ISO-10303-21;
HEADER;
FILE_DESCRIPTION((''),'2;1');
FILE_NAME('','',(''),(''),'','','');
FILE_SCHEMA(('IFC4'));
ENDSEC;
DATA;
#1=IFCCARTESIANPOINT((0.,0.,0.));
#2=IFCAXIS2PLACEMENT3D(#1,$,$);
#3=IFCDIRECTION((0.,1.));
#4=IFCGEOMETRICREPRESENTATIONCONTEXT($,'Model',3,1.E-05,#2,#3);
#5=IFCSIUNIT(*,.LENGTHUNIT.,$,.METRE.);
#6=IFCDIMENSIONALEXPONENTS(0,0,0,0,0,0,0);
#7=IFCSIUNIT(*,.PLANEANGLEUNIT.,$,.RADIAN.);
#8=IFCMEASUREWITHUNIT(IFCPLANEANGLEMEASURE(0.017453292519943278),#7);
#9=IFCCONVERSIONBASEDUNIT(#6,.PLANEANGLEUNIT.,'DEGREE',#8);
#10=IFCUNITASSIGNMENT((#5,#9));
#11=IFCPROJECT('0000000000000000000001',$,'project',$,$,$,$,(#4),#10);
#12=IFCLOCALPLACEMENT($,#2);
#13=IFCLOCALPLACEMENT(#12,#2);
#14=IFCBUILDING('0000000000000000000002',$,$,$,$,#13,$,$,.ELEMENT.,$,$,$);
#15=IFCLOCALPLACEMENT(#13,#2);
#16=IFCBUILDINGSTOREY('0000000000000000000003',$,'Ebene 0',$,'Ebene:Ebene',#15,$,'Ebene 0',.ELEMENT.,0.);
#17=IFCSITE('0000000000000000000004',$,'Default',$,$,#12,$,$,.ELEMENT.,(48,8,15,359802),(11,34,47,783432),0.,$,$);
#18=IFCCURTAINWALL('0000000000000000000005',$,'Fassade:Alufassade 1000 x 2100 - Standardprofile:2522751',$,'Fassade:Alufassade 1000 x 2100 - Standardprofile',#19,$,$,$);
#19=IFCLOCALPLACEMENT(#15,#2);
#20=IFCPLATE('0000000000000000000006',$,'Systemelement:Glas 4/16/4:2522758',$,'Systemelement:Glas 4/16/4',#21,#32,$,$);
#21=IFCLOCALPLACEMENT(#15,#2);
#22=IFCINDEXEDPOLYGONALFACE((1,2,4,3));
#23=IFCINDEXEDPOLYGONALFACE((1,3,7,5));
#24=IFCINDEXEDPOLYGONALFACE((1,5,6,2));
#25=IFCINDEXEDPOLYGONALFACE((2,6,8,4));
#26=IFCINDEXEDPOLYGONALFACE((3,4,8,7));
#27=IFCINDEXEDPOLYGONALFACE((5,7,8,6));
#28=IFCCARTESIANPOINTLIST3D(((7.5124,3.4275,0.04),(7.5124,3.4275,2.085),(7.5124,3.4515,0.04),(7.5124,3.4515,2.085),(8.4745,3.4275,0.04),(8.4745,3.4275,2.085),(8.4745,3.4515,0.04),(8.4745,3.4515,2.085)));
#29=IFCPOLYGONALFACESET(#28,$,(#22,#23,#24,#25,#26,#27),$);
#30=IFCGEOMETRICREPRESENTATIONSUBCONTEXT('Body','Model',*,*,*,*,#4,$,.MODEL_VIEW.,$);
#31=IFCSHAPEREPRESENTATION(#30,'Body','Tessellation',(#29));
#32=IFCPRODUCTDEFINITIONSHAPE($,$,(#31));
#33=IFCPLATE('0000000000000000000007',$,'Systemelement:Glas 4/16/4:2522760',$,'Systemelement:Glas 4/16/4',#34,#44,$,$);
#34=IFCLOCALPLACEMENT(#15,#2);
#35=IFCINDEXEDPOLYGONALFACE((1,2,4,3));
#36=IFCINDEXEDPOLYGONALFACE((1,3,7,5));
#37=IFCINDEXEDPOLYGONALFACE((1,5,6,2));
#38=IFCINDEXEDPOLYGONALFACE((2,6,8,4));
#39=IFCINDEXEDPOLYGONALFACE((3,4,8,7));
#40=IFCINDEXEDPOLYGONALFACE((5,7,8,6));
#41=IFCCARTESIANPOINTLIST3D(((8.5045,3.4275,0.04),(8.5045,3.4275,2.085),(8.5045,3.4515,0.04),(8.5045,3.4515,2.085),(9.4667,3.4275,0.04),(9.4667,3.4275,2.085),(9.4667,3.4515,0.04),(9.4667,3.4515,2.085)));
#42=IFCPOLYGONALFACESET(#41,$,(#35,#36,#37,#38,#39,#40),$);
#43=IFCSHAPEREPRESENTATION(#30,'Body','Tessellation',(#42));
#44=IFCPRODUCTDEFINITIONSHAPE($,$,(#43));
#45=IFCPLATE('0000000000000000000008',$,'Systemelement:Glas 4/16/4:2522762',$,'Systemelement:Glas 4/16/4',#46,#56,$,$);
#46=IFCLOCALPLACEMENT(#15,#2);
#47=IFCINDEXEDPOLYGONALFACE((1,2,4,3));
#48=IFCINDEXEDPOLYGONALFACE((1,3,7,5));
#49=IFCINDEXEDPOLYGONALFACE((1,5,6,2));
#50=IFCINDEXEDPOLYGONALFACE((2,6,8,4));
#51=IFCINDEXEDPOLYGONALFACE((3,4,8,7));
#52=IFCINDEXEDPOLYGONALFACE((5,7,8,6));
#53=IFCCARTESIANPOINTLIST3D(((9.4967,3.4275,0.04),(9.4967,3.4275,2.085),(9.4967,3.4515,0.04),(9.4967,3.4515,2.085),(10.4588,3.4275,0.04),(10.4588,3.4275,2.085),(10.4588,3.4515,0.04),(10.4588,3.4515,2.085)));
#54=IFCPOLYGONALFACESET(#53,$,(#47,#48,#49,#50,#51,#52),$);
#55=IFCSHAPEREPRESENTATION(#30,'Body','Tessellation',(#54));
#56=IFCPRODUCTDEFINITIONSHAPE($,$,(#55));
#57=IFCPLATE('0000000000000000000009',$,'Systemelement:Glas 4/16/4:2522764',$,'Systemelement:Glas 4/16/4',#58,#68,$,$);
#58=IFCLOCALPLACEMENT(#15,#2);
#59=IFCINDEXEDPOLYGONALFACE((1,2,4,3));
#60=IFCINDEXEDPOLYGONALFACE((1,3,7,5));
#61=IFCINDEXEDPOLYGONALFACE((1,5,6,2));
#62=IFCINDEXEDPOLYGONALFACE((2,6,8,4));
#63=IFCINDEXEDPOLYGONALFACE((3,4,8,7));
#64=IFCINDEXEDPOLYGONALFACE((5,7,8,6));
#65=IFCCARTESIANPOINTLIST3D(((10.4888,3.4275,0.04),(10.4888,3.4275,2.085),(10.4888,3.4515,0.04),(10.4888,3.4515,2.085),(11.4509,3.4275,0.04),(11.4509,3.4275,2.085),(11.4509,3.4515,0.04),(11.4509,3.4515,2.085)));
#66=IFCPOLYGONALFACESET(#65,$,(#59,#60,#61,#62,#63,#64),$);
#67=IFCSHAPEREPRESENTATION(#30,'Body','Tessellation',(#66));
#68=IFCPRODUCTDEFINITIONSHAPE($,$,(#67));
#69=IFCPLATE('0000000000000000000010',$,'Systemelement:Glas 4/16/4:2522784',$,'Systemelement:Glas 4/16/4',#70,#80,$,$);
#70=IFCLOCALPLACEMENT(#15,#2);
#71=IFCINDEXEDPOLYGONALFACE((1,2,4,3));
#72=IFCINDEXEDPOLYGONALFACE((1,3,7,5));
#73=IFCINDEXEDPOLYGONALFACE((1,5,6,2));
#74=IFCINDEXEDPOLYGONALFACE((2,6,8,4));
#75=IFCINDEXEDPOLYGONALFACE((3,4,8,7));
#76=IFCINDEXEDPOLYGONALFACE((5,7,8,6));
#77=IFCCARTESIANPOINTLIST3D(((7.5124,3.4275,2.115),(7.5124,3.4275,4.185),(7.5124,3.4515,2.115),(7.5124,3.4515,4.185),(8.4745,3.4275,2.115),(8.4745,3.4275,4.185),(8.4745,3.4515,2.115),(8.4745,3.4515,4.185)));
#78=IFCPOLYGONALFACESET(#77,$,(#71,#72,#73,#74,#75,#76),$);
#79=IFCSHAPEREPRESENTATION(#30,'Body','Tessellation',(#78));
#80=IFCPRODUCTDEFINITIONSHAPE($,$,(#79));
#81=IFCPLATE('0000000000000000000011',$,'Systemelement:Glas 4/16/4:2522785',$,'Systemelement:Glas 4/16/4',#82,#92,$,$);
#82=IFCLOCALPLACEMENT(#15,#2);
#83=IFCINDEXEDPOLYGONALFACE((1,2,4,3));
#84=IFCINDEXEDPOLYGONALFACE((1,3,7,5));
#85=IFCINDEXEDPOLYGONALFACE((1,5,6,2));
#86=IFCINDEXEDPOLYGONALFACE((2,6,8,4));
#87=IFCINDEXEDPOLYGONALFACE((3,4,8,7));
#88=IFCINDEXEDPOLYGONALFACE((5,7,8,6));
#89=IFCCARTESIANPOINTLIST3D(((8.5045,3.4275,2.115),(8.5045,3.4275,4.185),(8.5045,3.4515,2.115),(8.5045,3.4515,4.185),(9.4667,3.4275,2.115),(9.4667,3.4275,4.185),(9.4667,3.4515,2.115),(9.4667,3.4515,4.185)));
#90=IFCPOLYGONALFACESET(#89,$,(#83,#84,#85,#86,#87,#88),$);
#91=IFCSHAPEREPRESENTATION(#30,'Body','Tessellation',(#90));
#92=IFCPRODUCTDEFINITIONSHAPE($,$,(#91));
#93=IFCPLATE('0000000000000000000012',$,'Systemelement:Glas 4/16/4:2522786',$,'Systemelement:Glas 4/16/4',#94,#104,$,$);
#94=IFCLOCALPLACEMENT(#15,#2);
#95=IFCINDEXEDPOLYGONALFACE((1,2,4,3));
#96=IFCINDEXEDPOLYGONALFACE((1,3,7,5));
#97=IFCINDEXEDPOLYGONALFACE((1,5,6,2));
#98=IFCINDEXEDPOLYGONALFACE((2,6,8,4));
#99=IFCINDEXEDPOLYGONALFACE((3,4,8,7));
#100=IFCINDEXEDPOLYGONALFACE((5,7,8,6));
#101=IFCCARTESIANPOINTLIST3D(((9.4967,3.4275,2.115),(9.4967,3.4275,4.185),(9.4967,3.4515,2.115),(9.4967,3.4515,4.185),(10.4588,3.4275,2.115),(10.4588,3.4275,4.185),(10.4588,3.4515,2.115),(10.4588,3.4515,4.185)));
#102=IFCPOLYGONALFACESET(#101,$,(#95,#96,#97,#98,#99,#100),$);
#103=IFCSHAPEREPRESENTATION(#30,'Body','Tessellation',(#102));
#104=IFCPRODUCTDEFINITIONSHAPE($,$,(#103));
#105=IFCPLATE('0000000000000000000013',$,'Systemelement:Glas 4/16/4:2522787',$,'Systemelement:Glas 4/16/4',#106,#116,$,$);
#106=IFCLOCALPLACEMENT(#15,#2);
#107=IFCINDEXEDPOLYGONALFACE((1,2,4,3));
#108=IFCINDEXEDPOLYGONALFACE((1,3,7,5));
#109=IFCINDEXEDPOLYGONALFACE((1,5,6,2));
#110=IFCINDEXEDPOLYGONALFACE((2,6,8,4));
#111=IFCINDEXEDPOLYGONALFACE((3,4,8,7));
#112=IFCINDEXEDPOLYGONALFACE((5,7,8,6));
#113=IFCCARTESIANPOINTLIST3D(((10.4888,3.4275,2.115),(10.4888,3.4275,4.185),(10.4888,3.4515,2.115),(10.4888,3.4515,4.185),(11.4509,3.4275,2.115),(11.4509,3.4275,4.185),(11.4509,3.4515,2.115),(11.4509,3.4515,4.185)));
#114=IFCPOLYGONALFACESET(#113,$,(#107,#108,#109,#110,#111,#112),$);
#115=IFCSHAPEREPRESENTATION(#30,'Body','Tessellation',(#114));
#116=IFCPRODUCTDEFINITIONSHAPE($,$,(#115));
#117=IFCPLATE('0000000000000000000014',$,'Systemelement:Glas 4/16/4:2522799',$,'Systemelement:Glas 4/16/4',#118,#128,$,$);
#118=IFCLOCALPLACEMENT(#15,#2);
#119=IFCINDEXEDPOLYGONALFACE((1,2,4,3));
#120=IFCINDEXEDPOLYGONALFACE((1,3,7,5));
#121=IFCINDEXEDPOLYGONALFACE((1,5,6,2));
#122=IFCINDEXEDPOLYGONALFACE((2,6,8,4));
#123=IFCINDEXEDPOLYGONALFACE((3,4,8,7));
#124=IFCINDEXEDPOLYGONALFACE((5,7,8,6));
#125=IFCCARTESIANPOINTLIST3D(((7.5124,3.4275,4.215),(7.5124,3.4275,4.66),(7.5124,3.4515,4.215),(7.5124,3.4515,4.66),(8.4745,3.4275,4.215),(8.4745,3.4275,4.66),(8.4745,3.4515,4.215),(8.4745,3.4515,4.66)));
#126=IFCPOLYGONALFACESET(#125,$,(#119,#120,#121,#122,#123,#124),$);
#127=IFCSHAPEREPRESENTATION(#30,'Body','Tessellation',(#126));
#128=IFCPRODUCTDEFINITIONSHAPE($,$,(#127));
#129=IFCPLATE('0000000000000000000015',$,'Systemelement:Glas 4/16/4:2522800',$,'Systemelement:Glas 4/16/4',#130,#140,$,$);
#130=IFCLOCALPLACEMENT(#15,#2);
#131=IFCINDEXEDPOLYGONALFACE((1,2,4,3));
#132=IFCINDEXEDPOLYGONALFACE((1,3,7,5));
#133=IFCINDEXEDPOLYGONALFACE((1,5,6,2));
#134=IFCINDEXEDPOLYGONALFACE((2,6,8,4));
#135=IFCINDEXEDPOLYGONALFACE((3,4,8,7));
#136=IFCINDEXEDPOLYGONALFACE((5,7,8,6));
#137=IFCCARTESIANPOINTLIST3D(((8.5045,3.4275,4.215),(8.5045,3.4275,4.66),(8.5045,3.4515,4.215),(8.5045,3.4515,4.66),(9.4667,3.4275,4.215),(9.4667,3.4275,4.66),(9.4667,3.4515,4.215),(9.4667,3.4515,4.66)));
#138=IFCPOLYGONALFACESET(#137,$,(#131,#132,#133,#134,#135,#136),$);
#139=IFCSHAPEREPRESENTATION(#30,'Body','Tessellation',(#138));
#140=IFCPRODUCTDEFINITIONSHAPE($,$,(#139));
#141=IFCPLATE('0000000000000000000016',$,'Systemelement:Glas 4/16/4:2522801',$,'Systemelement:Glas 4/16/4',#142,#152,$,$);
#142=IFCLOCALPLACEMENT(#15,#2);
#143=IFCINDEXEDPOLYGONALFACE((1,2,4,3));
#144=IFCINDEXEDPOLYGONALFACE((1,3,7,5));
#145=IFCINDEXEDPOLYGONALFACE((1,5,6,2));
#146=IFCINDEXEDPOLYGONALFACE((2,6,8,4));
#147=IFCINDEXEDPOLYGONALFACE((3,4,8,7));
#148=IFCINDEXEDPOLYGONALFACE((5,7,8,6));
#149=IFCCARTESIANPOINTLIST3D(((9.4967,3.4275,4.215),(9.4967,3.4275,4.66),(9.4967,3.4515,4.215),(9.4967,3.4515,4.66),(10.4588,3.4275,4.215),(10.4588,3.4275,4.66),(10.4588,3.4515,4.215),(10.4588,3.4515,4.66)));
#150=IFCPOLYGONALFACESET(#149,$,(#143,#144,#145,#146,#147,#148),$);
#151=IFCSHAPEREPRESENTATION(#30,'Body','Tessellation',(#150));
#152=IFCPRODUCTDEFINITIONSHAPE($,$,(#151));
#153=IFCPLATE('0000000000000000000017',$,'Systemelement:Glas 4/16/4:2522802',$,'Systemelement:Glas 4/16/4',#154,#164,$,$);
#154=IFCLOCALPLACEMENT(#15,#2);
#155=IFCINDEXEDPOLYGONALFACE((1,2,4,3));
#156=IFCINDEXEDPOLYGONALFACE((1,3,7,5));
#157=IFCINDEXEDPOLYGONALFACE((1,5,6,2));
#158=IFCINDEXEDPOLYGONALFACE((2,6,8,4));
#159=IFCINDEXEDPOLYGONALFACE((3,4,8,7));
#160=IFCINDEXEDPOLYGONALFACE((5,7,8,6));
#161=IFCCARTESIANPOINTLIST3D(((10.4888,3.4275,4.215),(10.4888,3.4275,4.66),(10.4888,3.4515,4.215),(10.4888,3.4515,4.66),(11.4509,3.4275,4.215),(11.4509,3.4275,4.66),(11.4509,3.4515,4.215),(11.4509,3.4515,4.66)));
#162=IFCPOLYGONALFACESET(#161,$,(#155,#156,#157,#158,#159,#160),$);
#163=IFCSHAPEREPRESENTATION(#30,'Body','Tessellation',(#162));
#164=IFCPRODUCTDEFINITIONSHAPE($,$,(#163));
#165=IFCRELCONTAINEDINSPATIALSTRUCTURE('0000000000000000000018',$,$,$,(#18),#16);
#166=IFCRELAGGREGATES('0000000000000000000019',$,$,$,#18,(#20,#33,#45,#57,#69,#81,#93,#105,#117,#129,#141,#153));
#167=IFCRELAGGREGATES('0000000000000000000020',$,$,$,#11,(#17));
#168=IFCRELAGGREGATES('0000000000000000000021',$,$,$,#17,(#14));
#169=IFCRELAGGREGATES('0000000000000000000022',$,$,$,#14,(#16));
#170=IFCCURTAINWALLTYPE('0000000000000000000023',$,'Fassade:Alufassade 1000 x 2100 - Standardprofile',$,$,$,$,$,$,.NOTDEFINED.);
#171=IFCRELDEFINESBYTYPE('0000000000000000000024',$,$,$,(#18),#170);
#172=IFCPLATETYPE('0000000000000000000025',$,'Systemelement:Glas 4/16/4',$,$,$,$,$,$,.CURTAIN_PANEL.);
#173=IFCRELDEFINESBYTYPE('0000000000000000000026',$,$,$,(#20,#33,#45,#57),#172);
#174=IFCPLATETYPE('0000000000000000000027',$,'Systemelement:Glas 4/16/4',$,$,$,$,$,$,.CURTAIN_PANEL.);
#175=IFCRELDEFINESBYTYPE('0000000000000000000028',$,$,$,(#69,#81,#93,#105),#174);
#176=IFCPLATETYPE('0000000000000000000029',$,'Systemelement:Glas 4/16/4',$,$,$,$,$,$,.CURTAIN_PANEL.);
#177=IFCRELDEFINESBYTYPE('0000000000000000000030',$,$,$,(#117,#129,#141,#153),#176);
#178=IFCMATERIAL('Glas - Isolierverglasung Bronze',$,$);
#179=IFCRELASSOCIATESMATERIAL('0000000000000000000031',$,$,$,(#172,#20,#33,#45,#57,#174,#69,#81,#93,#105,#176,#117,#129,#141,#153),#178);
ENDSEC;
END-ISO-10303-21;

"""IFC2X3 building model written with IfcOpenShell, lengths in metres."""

from ifc_helpers import new_model, entity, si_unit, converted_unit, direction, frame, origin, origin_2d_with_axis, place, context, subcontext, project, spatial, rectangle, extrude, source, transform, mapped, material, type_object, type_shapes, element, aggregate, save


model = new_model("IFC2X3")

# Units and contexts
model_context = context("Model", 3, precision=1e-05, world=origin(), true_north=direction((0.0, 1.0)))
body_context = subcontext(model_context, "Body", "Model", "MODEL_VIEW")
ifc_project = project(units=[si_unit("LENGTHUNIT", "METRE"), converted_unit("PLANEANGLEUNIT", "DEGREE", entity("IfcPlaneAngleMeasure", 0.017453292519943278), si_unit("PLANEANGLEUNIT", "RADIAN"), dimensions=[0, 0, 0, 0, 0, 0, 0])], contexts=[model_context])

# Site, building, storey
site_placement = place(None, origin())
site = spatial("IfcSite", under=ifc_project, at=site_placement, Name="Default", CompositionType="ELEMENT", RefLatitude=(48, 8, 15, 359802), RefLongitude=(11, 34, 47, 783432), RefElevation=0.0)
building_placement = place(site_placement, origin())
building = spatial("IfcBuilding", under=site, at=building_placement, CompositionType="ELEMENT")
storey_placement = place(building_placement, origin())
storey = spatial("IfcBuildingStorey", under=building, at=storey_placement, Name="Ebene 0", ObjectType="Ebene:Ebene", LongName="Ebene 0", CompositionType="ELEMENT", Elevation=0.0)

# Curtain wall, plates
curtain_wall_type = type_object("IfcCurtainWallType", Name="Fassade:Alufassade 1000 x 2100 - Standardprofile", PredefinedType="NOTDEFINED")
curtain_wall_placement = place(storey_placement, origin())
curtain_wall = element("IfcCurtainWall", 1, at=curtain_wall_placement, inside=storey, type_object=curtain_wall_type, Name="Fassade:Alufassade 1000 x 2100 - Standardprofile:2522751", ObjectType="Fassade:Alufassade 1000 x 2100 - Standardprofile")
ifc_material_1 = material(Name="Glas - Isolierverglasung Bronze")
plate_type_1 = type_object("IfcPlateType", Name="Systemelement:Glas 4/16/4", PredefinedType="CURTAIN_PANEL", material=ifc_material_1)
shared_shape_1 = source(origin(), body_context, "Body", "SweptSolid", [
    extrude(rectangle(XDim=0.024, YDim=0.9621, at=origin_2d_with_axis()), frame((0.0, 0.0, 0.0), z_axis=(0.0, 0.0, 1.0), x_axis=(0.0, 1.0, 0.0)), (0.0, 0.0, 1.0), 2.045),
])
type_shapes(plate_type_1, [shared_shape_1])
plate_1_placement = place(curtain_wall_placement, frame((7.9934, 3.4395, 0.04)))
plate_1 = element("IfcPlate", 2, at=plate_1_placement, type_object=plate_type_1, material=ifc_material_1, Name="Systemelement:Glas 4/16/4:2522758", ObjectType="Systemelement:Glas 4/16/4", context=body_context, shape_type="MappedRepresentation", body=[
    mapped(shared_shape_1, transform((0.0, 0.0, 0.0), scale=1.0)),
])
plate_2_placement = place(curtain_wall_placement, frame((8.9856, 3.4395, 0.04)))
plate_2 = element("IfcPlate", 3, at=plate_2_placement, type_object=plate_type_1, material=ifc_material_1, Name="Systemelement:Glas 4/16/4:2522760", ObjectType="Systemelement:Glas 4/16/4", context=body_context, shape_type="MappedRepresentation", body=[
    mapped(shared_shape_1, transform((0.0, 0.0, 0.0), scale=1.0)),
])
plate_3_placement = place(curtain_wall_placement, frame((9.9777, 3.4395, 0.04)))
plate_3 = element("IfcPlate", 4, at=plate_3_placement, type_object=plate_type_1, material=ifc_material_1, Name="Systemelement:Glas 4/16/4:2522762", ObjectType="Systemelement:Glas 4/16/4", context=body_context, shape_type="MappedRepresentation", body=[
    mapped(shared_shape_1, transform((0.0, 0.0, 0.0), scale=1.0)),
])
plate_4_placement = place(curtain_wall_placement, frame((10.9699, 3.4395, 0.04)))
plate_4 = element("IfcPlate", 5, at=plate_4_placement, type_object=plate_type_1, material=ifc_material_1, Name="Systemelement:Glas 4/16/4:2522764", ObjectType="Systemelement:Glas 4/16/4", context=body_context, shape_type="MappedRepresentation", body=[
    mapped(shared_shape_1, transform((0.0, 0.0, 0.0), scale=1.0)),
])
plate_type_2 = type_object("IfcPlateType", Name="Systemelement:Glas 4/16/4", PredefinedType="CURTAIN_PANEL", material=ifc_material_1)
shared_shape_2 = source(origin(), body_context, "Body", "SweptSolid", [
    extrude(rectangle(XDim=0.024, YDim=0.9621, at=origin_2d_with_axis()), frame((0.0, 0.0, 0.0), z_axis=(0.0, 0.0, 1.0), x_axis=(0.0, 1.0, 0.0)), (0.0, 0.0, 1.0), 2.07),
])
type_shapes(plate_type_2, [shared_shape_2])
plate_5_placement = place(curtain_wall_placement, frame((7.9934, 3.4395, 2.115)))
plate_5 = element("IfcPlate", 6, at=plate_5_placement, type_object=plate_type_2, material=ifc_material_1, Name="Systemelement:Glas 4/16/4:2522784", ObjectType="Systemelement:Glas 4/16/4", context=body_context, shape_type="MappedRepresentation", body=[
    mapped(shared_shape_2, transform((0.0, 0.0, 0.0), scale=1.0)),
])
plate_6_placement = place(curtain_wall_placement, frame((8.9856, 3.4395, 2.115)))
plate_6 = element("IfcPlate", 7, at=plate_6_placement, type_object=plate_type_2, material=ifc_material_1, Name="Systemelement:Glas 4/16/4:2522785", ObjectType="Systemelement:Glas 4/16/4", context=body_context, shape_type="MappedRepresentation", body=[
    mapped(shared_shape_2, transform((0.0, 0.0, 0.0), scale=1.0)),
])
plate_7_placement = place(curtain_wall_placement, frame((9.9777, 3.4395, 2.115)))
plate_7 = element("IfcPlate", 8, at=plate_7_placement, type_object=plate_type_2, material=ifc_material_1, Name="Systemelement:Glas 4/16/4:2522786", ObjectType="Systemelement:Glas 4/16/4", context=body_context, shape_type="MappedRepresentation", body=[
    mapped(shared_shape_2, transform((0.0, 0.0, 0.0), scale=1.0)),
])
plate_8_placement = place(curtain_wall_placement, frame((10.9699, 3.4395, 2.115)))
plate_8 = element("IfcPlate", 9, at=plate_8_placement, type_object=plate_type_2, material=ifc_material_1, Name="Systemelement:Glas 4/16/4:2522787", ObjectType="Systemelement:Glas 4/16/4", context=body_context, shape_type="MappedRepresentation", body=[
    mapped(shared_shape_2, transform((0.0, 0.0, 0.0), scale=1.0)),
])
plate_type_3 = type_object("IfcPlateType", Name="Systemelement:Glas 4/16/4", PredefinedType="CURTAIN_PANEL", material=ifc_material_1)
shared_shape_3 = source(origin(), body_context, "Body", "SweptSolid", [
    extrude(rectangle(XDim=0.024, YDim=0.9621, at=origin_2d_with_axis()), frame((0.0, 0.0, 0.0), z_axis=(0.0, 0.0, 1.0), x_axis=(0.0, 1.0, 0.0)), (0.0, 0.0, 1.0), 0.445),
])
type_shapes(plate_type_3, [shared_shape_3])
plate_9_placement = place(curtain_wall_placement, frame((7.9934, 3.4395, 4.215)))
plate_9 = element("IfcPlate", 10, at=plate_9_placement, type_object=plate_type_3, material=ifc_material_1, Name="Systemelement:Glas 4/16/4:2522799", ObjectType="Systemelement:Glas 4/16/4", context=body_context, shape_type="MappedRepresentation", body=[
    mapped(shared_shape_3, transform((0.0, 0.0, 0.0), scale=1.0)),
])
plate_10_placement = place(curtain_wall_placement, frame((8.9856, 3.4395, 4.215)))
plate_10 = element("IfcPlate", 11, at=plate_10_placement, type_object=plate_type_3, material=ifc_material_1, Name="Systemelement:Glas 4/16/4:2522800", ObjectType="Systemelement:Glas 4/16/4", context=body_context, shape_type="MappedRepresentation", body=[
    mapped(shared_shape_3, transform((0.0, 0.0, 0.0), scale=1.0)),
])
plate_11_placement = place(curtain_wall_placement, frame((9.9777, 3.4395, 4.215)))
plate_11 = element("IfcPlate", 12, at=plate_11_placement, type_object=plate_type_3, material=ifc_material_1, Name="Systemelement:Glas 4/16/4:2522801", ObjectType="Systemelement:Glas 4/16/4", context=body_context, shape_type="MappedRepresentation", body=[
    mapped(shared_shape_3, transform((0.0, 0.0, 0.0), scale=1.0)),
])
plate_12_placement = place(curtain_wall_placement, frame((10.9699, 3.4395, 4.215)))
plate_12 = element("IfcPlate", 13, at=plate_12_placement, type_object=plate_type_3, material=ifc_material_1, Name="Systemelement:Glas 4/16/4:2522802", ObjectType="Systemelement:Glas 4/16/4", context=body_context, shape_type="MappedRepresentation", body=[
    mapped(shared_shape_3, transform((0.0, 0.0, 0.0), scale=1.0)),
])
aggregate(curtain_wall, [plate_1, plate_2, plate_3, plate_4, plate_5, plate_6, plate_7, plate_8, plate_9, plate_10, plate_11, plate_12])

save(model, "model.ifc")
